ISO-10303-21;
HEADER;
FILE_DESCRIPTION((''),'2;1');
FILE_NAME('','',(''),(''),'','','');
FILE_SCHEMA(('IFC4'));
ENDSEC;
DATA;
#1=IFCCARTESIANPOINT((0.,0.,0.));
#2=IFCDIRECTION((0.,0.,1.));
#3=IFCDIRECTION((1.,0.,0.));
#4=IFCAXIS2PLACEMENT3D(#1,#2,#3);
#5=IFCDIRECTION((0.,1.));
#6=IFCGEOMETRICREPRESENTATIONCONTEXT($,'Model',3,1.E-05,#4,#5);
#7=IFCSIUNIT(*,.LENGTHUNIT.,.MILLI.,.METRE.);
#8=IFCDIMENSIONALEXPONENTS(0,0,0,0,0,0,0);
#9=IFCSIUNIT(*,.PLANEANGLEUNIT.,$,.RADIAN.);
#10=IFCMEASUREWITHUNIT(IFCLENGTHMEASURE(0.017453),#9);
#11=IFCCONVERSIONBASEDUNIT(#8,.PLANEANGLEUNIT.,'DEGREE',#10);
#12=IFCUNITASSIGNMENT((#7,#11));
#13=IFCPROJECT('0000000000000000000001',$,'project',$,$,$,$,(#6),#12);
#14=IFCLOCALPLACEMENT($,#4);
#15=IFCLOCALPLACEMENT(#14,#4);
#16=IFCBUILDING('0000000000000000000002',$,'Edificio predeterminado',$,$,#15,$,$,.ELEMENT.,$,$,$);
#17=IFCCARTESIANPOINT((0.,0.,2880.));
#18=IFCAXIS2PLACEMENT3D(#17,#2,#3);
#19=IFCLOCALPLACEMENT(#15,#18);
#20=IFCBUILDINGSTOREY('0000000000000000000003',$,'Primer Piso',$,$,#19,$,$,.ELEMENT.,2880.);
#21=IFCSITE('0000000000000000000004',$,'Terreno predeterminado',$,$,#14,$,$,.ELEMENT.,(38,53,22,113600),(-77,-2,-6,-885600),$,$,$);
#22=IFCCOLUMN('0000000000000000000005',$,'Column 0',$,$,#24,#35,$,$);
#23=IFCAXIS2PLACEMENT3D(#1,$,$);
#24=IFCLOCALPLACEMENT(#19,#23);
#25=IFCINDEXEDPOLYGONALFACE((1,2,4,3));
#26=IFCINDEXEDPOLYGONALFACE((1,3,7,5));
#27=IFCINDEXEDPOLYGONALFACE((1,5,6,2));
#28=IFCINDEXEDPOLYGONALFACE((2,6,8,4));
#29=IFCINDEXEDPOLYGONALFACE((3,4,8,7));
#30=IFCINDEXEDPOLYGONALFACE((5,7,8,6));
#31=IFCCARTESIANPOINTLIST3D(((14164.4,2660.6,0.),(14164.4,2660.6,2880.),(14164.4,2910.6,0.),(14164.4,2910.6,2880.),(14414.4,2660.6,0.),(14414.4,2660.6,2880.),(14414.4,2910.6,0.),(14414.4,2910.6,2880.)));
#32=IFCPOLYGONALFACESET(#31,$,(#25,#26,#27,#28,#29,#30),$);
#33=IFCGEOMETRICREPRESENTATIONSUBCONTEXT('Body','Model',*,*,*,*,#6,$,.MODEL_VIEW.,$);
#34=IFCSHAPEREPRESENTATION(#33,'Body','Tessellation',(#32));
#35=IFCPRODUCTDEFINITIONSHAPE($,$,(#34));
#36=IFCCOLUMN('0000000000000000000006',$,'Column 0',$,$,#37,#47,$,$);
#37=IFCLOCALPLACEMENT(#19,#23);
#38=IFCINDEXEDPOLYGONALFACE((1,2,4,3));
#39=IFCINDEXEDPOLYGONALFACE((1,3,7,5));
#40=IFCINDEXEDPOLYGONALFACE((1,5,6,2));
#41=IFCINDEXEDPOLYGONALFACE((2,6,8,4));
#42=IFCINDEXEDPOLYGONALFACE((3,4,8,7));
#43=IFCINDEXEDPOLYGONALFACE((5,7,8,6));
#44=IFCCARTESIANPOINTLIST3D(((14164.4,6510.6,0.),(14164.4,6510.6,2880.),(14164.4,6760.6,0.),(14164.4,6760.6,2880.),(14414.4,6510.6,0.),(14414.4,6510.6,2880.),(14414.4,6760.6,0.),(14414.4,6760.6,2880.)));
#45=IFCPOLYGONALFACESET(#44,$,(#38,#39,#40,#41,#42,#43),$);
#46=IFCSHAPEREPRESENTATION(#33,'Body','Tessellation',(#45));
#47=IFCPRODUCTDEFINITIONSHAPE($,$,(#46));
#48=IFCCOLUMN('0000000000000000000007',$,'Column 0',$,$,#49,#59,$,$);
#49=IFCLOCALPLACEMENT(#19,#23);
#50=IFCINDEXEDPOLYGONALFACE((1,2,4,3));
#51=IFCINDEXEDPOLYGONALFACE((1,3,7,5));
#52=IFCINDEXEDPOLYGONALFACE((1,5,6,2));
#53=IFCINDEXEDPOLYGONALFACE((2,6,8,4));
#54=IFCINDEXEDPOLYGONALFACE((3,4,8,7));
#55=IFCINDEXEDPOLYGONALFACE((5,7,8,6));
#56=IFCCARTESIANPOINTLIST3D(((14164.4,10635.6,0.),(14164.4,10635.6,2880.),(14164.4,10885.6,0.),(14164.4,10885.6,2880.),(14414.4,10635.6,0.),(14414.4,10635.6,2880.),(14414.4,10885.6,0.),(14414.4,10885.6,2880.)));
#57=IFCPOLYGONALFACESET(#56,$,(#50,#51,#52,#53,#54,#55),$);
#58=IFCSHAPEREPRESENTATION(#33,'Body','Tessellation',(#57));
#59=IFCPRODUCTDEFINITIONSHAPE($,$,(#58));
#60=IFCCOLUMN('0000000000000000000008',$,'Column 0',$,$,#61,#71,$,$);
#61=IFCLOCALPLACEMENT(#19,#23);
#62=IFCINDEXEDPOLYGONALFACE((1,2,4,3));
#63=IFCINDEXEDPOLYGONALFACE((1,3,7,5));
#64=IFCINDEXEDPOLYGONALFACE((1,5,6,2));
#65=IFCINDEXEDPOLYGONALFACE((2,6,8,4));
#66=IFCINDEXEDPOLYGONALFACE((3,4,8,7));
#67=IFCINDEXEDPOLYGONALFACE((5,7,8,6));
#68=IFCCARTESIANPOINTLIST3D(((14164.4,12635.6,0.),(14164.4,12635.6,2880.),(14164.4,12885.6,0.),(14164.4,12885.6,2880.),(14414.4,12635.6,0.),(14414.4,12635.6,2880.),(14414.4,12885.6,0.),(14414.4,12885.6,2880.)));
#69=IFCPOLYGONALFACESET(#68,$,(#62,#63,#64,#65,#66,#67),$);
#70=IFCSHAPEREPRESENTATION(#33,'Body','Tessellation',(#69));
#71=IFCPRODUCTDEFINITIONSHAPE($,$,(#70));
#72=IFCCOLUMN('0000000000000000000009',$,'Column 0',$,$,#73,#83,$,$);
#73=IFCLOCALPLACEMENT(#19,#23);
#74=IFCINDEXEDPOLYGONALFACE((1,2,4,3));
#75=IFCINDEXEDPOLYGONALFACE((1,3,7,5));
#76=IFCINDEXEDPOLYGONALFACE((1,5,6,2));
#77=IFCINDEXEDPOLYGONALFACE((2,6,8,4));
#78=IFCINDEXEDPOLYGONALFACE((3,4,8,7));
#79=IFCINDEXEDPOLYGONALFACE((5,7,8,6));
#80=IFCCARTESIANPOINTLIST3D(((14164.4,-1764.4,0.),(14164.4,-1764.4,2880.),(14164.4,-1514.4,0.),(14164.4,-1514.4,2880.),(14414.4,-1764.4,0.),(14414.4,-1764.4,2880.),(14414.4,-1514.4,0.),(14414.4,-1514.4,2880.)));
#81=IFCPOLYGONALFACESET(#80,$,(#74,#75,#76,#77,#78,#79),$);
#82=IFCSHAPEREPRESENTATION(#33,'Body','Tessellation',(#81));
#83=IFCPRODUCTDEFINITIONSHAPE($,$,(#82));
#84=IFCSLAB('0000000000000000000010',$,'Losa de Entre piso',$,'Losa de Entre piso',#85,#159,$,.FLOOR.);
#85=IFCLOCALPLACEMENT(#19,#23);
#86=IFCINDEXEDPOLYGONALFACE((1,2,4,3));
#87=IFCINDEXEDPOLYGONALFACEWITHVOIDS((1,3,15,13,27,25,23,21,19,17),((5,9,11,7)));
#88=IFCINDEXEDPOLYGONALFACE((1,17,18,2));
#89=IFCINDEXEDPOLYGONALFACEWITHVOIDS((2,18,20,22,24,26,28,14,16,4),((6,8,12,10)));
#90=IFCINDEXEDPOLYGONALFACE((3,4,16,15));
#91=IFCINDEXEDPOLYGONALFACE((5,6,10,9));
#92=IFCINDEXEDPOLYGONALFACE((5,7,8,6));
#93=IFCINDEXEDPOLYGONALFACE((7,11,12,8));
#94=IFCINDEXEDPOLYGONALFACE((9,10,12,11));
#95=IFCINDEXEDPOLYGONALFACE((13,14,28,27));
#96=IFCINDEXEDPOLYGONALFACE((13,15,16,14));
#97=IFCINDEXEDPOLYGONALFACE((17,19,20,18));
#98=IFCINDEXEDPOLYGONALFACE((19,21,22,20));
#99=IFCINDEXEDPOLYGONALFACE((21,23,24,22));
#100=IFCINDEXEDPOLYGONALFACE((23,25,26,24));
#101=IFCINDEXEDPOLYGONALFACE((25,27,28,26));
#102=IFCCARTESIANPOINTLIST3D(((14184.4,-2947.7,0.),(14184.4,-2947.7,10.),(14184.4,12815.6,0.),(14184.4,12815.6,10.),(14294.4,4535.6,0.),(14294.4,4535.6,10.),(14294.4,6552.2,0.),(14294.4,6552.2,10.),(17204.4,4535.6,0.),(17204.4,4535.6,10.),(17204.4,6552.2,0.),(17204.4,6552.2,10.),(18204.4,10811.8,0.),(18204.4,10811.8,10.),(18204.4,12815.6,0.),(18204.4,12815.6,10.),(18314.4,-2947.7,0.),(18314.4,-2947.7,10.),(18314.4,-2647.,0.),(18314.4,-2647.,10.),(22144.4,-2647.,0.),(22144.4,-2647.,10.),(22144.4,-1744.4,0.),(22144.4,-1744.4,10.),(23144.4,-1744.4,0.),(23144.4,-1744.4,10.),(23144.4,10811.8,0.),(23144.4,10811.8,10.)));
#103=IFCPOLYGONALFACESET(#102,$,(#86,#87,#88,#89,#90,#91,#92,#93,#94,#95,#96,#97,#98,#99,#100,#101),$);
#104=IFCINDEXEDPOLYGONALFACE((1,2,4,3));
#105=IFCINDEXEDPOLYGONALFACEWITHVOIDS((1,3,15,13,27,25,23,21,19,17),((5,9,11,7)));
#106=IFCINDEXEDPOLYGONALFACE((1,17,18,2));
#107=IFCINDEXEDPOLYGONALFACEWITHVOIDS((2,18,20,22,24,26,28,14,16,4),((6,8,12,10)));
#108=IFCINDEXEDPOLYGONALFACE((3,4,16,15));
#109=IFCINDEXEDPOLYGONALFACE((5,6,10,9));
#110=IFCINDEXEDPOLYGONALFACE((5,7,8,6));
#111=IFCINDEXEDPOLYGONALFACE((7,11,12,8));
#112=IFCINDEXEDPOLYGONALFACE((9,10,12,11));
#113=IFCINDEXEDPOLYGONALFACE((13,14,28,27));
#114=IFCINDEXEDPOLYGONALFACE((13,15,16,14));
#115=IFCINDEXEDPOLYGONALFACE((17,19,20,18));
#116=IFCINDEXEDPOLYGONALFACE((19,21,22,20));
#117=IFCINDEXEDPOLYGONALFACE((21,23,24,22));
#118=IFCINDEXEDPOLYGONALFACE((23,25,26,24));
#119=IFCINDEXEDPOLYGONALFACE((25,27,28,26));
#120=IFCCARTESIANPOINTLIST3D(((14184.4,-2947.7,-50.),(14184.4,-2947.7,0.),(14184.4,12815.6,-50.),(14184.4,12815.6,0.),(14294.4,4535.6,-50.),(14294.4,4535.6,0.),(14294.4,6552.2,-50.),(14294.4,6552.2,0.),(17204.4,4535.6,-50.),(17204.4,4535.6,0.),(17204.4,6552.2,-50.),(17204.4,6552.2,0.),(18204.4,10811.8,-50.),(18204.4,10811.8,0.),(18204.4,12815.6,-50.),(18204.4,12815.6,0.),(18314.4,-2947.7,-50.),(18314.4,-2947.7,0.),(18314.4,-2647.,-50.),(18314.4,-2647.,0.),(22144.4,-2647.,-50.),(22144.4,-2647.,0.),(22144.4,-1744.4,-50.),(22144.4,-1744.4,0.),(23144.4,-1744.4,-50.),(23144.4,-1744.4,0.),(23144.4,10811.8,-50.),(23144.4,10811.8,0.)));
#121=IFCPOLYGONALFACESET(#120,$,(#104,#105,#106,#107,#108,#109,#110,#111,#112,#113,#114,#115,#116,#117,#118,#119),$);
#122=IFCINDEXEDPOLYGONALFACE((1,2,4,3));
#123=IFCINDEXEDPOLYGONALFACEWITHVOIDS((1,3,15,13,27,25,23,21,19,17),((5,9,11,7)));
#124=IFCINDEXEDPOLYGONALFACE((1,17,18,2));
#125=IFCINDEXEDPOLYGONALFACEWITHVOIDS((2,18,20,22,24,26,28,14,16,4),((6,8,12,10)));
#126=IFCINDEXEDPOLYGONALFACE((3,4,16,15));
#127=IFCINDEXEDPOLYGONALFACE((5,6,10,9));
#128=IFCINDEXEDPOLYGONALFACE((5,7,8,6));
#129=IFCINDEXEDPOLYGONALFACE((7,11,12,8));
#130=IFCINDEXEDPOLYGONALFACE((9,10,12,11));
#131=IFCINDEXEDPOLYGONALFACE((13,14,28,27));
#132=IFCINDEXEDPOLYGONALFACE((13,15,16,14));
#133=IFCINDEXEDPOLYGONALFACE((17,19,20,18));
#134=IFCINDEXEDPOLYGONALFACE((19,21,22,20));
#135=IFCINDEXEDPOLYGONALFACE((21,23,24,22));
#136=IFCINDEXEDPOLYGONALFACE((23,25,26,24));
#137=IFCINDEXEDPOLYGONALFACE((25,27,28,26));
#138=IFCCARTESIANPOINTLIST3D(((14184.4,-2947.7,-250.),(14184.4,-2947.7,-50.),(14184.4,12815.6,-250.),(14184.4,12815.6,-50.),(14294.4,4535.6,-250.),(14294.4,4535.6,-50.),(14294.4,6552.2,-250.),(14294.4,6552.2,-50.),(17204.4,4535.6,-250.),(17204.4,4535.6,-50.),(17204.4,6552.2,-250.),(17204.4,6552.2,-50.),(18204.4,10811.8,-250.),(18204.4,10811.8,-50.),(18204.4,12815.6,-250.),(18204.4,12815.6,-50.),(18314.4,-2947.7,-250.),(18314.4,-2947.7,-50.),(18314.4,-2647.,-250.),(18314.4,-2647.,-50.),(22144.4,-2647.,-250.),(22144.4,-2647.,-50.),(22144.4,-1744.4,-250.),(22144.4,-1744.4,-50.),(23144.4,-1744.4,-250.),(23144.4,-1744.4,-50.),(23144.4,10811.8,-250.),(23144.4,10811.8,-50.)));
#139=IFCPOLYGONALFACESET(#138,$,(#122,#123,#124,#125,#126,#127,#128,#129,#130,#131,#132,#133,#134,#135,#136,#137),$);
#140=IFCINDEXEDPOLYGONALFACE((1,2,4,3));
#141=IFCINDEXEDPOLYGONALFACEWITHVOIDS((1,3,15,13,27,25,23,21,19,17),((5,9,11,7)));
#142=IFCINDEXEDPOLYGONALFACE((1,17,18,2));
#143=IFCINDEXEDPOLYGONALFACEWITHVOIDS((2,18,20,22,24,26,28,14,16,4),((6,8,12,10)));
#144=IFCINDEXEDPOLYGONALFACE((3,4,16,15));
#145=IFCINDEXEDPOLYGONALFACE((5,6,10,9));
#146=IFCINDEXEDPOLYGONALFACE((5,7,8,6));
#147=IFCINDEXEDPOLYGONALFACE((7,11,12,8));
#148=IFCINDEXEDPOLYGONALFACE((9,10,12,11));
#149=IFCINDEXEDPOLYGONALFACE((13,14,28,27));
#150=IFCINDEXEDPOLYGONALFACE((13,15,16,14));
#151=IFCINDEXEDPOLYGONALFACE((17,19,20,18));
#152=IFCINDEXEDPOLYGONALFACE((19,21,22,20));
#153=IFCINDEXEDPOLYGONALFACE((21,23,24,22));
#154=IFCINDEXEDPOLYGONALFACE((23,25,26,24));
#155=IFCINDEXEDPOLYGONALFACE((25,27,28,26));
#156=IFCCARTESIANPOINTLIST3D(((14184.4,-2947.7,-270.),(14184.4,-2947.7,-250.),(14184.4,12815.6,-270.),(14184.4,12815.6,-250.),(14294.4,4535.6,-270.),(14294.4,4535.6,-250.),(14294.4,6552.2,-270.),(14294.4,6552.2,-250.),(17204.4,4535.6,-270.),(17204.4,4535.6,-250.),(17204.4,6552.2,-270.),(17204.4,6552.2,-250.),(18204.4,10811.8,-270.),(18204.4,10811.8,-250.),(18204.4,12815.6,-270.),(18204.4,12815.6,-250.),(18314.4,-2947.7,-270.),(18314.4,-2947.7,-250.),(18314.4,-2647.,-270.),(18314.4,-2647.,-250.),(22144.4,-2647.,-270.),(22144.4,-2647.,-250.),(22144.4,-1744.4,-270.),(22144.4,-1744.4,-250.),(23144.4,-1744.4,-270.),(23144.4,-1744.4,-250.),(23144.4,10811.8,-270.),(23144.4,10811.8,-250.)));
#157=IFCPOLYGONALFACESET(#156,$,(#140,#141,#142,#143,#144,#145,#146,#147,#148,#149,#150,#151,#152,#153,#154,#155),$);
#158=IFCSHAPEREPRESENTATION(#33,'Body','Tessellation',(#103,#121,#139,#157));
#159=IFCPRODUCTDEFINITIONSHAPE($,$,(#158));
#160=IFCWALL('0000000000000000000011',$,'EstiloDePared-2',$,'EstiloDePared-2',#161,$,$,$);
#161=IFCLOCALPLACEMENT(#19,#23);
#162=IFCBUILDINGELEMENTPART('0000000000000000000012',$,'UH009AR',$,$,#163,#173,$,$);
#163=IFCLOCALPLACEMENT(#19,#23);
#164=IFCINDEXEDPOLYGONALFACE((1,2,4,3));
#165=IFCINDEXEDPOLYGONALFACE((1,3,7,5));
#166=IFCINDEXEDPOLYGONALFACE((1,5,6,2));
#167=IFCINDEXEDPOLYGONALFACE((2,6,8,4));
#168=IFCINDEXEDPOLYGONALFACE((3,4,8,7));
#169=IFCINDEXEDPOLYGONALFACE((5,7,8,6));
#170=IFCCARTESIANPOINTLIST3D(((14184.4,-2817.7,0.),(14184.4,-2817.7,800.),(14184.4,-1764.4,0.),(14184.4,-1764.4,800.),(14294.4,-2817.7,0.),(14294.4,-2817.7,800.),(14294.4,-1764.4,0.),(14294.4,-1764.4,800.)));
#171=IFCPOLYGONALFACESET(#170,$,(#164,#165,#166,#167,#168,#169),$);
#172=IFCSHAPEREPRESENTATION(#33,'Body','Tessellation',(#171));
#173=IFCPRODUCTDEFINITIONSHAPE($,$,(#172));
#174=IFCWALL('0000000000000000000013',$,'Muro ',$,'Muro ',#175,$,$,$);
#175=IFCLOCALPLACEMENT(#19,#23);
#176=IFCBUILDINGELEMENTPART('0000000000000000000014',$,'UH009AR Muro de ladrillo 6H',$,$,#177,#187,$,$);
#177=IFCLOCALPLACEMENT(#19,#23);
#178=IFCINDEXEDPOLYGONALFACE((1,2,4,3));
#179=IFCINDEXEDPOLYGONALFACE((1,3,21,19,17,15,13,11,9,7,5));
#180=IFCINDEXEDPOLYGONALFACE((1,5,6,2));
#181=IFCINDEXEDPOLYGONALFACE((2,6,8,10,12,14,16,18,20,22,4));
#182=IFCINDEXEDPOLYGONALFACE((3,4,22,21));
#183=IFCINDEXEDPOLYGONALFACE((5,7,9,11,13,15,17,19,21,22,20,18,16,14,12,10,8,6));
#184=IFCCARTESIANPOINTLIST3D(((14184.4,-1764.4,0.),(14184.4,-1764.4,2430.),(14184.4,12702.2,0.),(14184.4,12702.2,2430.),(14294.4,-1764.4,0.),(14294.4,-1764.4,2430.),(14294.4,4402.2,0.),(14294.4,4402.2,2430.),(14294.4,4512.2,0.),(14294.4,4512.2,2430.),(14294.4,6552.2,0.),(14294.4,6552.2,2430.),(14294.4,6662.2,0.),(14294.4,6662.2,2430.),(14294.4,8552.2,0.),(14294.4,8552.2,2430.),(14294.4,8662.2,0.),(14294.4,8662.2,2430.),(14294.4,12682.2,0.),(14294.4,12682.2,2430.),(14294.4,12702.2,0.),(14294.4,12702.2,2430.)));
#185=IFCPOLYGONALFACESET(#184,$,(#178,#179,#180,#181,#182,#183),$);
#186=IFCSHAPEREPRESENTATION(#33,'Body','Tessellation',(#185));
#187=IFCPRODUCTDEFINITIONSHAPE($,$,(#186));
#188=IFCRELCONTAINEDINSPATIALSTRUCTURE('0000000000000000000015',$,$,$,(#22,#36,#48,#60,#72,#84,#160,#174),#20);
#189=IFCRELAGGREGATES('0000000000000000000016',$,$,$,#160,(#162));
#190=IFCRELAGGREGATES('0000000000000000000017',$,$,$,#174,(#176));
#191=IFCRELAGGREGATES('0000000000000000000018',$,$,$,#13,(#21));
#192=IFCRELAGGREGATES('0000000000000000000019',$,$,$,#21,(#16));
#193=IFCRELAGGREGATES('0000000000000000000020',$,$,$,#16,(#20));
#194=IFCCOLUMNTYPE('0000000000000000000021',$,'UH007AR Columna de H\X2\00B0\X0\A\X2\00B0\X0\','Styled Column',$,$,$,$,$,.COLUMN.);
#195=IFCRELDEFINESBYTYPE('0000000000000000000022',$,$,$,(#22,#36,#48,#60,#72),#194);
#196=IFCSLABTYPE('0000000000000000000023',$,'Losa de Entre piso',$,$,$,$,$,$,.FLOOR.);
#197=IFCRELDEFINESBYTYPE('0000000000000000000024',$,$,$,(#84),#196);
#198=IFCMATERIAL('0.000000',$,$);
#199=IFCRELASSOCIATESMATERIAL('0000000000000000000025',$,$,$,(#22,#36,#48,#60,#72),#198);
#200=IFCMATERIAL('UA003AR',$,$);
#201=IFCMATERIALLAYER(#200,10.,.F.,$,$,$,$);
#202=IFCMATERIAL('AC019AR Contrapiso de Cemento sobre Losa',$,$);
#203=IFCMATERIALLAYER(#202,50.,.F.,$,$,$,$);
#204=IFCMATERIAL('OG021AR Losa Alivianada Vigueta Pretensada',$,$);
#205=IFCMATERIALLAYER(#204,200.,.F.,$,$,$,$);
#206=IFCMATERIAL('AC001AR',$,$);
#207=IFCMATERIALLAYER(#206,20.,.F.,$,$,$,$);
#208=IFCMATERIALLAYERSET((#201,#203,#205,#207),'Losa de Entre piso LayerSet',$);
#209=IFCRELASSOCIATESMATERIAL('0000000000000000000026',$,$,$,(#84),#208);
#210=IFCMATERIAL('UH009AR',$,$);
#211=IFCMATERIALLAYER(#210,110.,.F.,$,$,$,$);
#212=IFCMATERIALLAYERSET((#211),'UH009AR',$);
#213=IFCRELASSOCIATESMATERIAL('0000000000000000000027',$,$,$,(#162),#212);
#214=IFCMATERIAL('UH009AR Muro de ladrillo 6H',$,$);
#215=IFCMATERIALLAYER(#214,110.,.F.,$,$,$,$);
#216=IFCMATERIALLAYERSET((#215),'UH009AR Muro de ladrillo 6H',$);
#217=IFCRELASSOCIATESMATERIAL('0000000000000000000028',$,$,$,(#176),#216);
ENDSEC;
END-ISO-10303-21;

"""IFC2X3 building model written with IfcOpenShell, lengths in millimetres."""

from ifc_helpers import new_model, entity, si_unit, converted_unit, direction, frame, origin_with_axes, place, context, subcontext, project, spatial, polyline, outline, extrude, material, layer, layer_set, layer_usage, type_object, element, aggregate, save


model = new_model("IFC2X3")

# Units and contexts
model_context = context("Model", 3, precision=1e-05, world=origin_with_axes(), true_north=direction((0.0, 1.0)))
body_context = subcontext(model_context, "Body", "Model", "MODEL_VIEW")
ifc_project = project(units=[si_unit("LENGTHUNIT", "METRE", prefix="MILLI"), converted_unit("PLANEANGLEUNIT", "DEGREE", entity("IfcLengthMeasure", 0.017453), si_unit("PLANEANGLEUNIT", "RADIAN"), dimensions=[0, 0, 0, 0, 0, 0, 0])], contexts=[model_context])

# Site, building, storey
site_placement = place(None, origin_with_axes())
site = spatial("IfcSite", under=ifc_project, at=site_placement, Name="Terreno predeterminado", CompositionType="ELEMENT", RefLatitude=(38, 53, 22, 113600), RefLongitude=(-77, -2, -6, -885600))
building_placement = place(site_placement, origin_with_axes())
building = spatial("IfcBuilding", under=site, at=building_placement, Name="Edificio predeterminado", CompositionType="ELEMENT")
storey_placement = place(building_placement, frame((0.0, 0.0, 2880.0), z_axis=(0.0, 0.0, 1.0), x_axis=(1.0, 0.0, 0.0)))
storey = spatial("IfcBuildingStorey", under=building, at=storey_placement, Name="Primer Piso", CompositionType="ELEMENT", Elevation=2880.0)

# Columns
ifc_material_1 = material(Name="0.000000")
column_type = type_object("IfcColumnType", Name="UH007AR Columna de H°A°", Description="Styled Column", PredefinedType="COLUMN")
for number, where, z_axis, x_axis, name in (
    (1, (14289.4, 2785.6, 0.0), (0.0, 0.0, 1.0), (1.0, 0.0, 0.0), "Column 0"),
    (2, (14289.4, 6635.6, 0.0), (0.0, 0.0, 1.0), (1.0, 0.0, 0.0), "Column 0"),
    (3, (14289.4, 10760.6, 0.0), (0.0, 0.0, 1.0), (1.0, 0.0, 0.0), "Column 0"),
    (4, (14289.4, 12760.6, 0.0), (0.0, 0.0, 1.0), (1.0, 0.0, 0.0), "Column 0"),
    (5, (14289.4, -1639.4, 0.0), (0.0, 0.0, 1.0), (1.0, 0.0, 0.0), "Column 0"),
):
    element("IfcColumn", number, at=place(storey_placement, frame(where, z_axis=z_axis, x_axis=x_axis)), inside=storey, type_object=column_type, material=ifc_material_1, Name=name, context=body_context, shape_type="SweptSolid", body=[
        extrude(outline(polyline([(-125.0, -125.0), (125.0, -125.0), (125.0, 125.0), (-125.0, 125.0), (-125.0, -125.0)])), origin_with_axes(), (0.0, 0.0, 1.0), 2880.0),
    ])

# Slab
ifc_material_2 = material(Name="UA003AR")
ifc_layer_1 = layer(ifc_material_2, 10.0, ventilated=False)
ifc_material_3 = material(Name="AC019AR Contrapiso de Cemento sobre Losa")
ifc_layer_2 = layer(ifc_material_3, 50.0, ventilated=False)
ifc_material_4 = material(Name="OG021AR Losa Alivianada Vigueta Pretensada")
ifc_layer_3 = layer(ifc_material_4, 200.0, ventilated=False)
ifc_material_5 = material(Name="AC001AR")
ifc_layer_4 = layer(ifc_material_5, 20.0, ventilated=False)
ifc_layer_set_1 = layer_set([ifc_layer_1, ifc_layer_2, ifc_layer_3, ifc_layer_4], Name="Losa de Entre piso LayerSet")
ifc_layer_usage_1 = layer_usage(ifc_layer_set_1, "AXIS3", "NEGATIVE", 0.0)
slab_type = type_object("IfcSlabType", Name="Losa de Entre piso", PredefinedType="FLOOR")
slab_placement = place(storey_placement, frame((0.0, 0.0, -2880.0), z_axis=(0.0, 0.0, 1.0), x_axis=(1.0, 0.0, 0.0)))
element("IfcSlab", 6, at=slab_placement, inside=storey, type_object=slab_type, material=ifc_layer_usage_1, Name="Losa de Entre piso", ObjectType="Losa de Entre piso", PredefinedType="FLOOR", context=body_context, shape_type="SweptSolid", body=[
    extrude(outline(polyline([(0.0, 15763.4), (4130.0, 15763.4), (4130.0, 15462.6), (7960.0, 15462.6), (7960.0, 14560.0), (8960.0, 14560.0), (8960.0, 2003.8), (4020.0, 2003.8), (4020.0, 0.0), (0.0, 0.0), (0.0, 15763.4)]), holes=[polyline([(110.0, 6263.4), (3020.0, 6263.4), (3020.0, 8280.0), (110.0, 8280.0), (110.0, 6263.4)])]), frame((14184.4, 12815.6, 2880.0), z_axis=(0.0, 0.0, -1.0), x_axis=(1.0, 0.0, 0.0)), (0.0, 0.0, -1.0), 10.0),
    extrude(outline(polyline([(0.0, 15763.4), (4130.0, 15763.4), (4130.0, 15462.6), (7960.0, 15462.6), (7960.0, 14560.0), (8960.0, 14560.0), (8960.0, 2003.8), (4020.0, 2003.8), (4020.0, 0.0), (0.0, 0.0), (0.0, 15763.4)]), holes=[polyline([(110.0, 6263.4), (3020.0, 6263.4), (3020.0, 8280.0), (110.0, 8280.0), (110.0, 6263.4)])]), frame((14184.4, 12815.6, 2830.0), z_axis=(0.0, 0.0, -1.0), x_axis=(1.0, 0.0, 0.0)), (0.0, 0.0, -1.0), 50.0),
    extrude(outline(polyline([(0.0, 15763.4), (4130.0, 15763.4), (4130.0, 15462.6), (7960.0, 15462.6), (7960.0, 14560.0), (8960.0, 14560.0), (8960.0, 2003.8), (4020.0, 2003.8), (4020.0, 0.0), (0.0, 0.0), (0.0, 15763.4)]), holes=[polyline([(110.0, 6263.4), (3020.0, 6263.4), (3020.0, 8280.0), (110.0, 8280.0), (110.0, 6263.4)])]), frame((14184.4, 12815.6, 2630.0), z_axis=(0.0, 0.0, -1.0), x_axis=(1.0, 0.0, 0.0)), (0.0, 0.0, -1.0), 200.0),
    extrude(outline(polyline([(0.0, 15763.4), (4130.0, 15763.4), (4130.0, 15462.6), (7960.0, 15462.6), (7960.0, 14560.0), (8960.0, 14560.0), (8960.0, 2003.8), (4020.0, 2003.8), (4020.0, 0.0), (0.0, 0.0), (0.0, 15763.4)]), holes=[polyline([(110.0, 6263.4), (3020.0, 6263.4), (3020.0, 8280.0), (110.0, 8280.0), (110.0, 6263.4)])]), frame((14184.4, 12815.6, 2610.0), z_axis=(0.0, 0.0, -1.0), x_axis=(1.0, 0.0, 0.0)), (0.0, 0.0, -1.0), 20.0),
])

# Walls, building element parts
wall_1_placement = place(storey_placement, frame((14239.4, -2817.7, 0.0), z_axis=(0.0, 0.0, 1.0), x_axis=(0.0, 1.0, 0.0)))
wall_1 = element("IfcWall", 7, at=wall_1_placement, inside=storey, Name="EstiloDePared-2", ObjectType="EstiloDePared-2")
ifc_material_6 = material(Name="UH009AR")
ifc_layer_5 = layer(ifc_material_6, 110.0, ventilated=False)
ifc_layer_set_2 = layer_set([ifc_layer_5], Name="UH009AR")
ifc_layer_usage_2 = layer_usage(ifc_layer_set_2, "AXIS2", "NEGATIVE", -55.0)
building_element_part_1_placement = place(wall_1_placement, origin_with_axes())
building_element_part_1 = element("IfcBuildingElementPart", 8, at=building_element_part_1_placement, material=ifc_layer_usage_2, Name="UH009AR", context=body_context, shape_type="SweptSolid", body=[
    extrude(outline(polyline([(1053.4, 55.0), (1053.4, -55.0), (0.0, -55.0), (0.0, 55.0), (1053.4, 55.0)])), origin_with_axes(), (0.0, 0.0, 1.0), 800.0),
])
aggregate(wall_1, [building_element_part_1])
wall_2_placement = place(storey_placement, frame((14239.4, -1764.4, 0.0), z_axis=(0.0, 0.0, 1.0), x_axis=(0.0, 1.0, 0.0)))
wall_2 = element("IfcWall", 9, at=wall_2_placement, inside=storey, Name="Muro ", ObjectType="Muro ")
ifc_material_7 = material(Name="UH009AR Muro de ladrillo 6H")
ifc_layer_6 = layer(ifc_material_7, 110.0, ventilated=False)
ifc_layer_set_3 = layer_set([ifc_layer_6], Name="UH009AR Muro de ladrillo 6H")
ifc_layer_usage_3 = layer_usage(ifc_layer_set_3, "AXIS2", "NEGATIVE", -55.0)
building_element_part_2_placement = place(wall_2_placement, origin_with_axes())
building_element_part_2 = element("IfcBuildingElementPart", 10, at=building_element_part_2_placement, material=ifc_layer_usage_3, Name="UH009AR Muro de ladrillo 6H", context=body_context, shape_type="SweptSolid", body=[
    extrude(outline(polyline([(14466.6, 55.0), (14466.6, -55.0), (14446.6, -55.0), (10426.6, -55.0), (10316.6, -55.0), (8426.6, -55.0), (8316.6, -55.0), (6276.6, -55.0), (6166.6, -55.0), (0.0, -55.0), (0.0, 55.0), (14466.6, 55.0)])), origin_with_axes(), (0.0, 0.0, 1.0), 2430.0),
])
aggregate(wall_2, [building_element_part_2])

save(model, "model.ifc")
